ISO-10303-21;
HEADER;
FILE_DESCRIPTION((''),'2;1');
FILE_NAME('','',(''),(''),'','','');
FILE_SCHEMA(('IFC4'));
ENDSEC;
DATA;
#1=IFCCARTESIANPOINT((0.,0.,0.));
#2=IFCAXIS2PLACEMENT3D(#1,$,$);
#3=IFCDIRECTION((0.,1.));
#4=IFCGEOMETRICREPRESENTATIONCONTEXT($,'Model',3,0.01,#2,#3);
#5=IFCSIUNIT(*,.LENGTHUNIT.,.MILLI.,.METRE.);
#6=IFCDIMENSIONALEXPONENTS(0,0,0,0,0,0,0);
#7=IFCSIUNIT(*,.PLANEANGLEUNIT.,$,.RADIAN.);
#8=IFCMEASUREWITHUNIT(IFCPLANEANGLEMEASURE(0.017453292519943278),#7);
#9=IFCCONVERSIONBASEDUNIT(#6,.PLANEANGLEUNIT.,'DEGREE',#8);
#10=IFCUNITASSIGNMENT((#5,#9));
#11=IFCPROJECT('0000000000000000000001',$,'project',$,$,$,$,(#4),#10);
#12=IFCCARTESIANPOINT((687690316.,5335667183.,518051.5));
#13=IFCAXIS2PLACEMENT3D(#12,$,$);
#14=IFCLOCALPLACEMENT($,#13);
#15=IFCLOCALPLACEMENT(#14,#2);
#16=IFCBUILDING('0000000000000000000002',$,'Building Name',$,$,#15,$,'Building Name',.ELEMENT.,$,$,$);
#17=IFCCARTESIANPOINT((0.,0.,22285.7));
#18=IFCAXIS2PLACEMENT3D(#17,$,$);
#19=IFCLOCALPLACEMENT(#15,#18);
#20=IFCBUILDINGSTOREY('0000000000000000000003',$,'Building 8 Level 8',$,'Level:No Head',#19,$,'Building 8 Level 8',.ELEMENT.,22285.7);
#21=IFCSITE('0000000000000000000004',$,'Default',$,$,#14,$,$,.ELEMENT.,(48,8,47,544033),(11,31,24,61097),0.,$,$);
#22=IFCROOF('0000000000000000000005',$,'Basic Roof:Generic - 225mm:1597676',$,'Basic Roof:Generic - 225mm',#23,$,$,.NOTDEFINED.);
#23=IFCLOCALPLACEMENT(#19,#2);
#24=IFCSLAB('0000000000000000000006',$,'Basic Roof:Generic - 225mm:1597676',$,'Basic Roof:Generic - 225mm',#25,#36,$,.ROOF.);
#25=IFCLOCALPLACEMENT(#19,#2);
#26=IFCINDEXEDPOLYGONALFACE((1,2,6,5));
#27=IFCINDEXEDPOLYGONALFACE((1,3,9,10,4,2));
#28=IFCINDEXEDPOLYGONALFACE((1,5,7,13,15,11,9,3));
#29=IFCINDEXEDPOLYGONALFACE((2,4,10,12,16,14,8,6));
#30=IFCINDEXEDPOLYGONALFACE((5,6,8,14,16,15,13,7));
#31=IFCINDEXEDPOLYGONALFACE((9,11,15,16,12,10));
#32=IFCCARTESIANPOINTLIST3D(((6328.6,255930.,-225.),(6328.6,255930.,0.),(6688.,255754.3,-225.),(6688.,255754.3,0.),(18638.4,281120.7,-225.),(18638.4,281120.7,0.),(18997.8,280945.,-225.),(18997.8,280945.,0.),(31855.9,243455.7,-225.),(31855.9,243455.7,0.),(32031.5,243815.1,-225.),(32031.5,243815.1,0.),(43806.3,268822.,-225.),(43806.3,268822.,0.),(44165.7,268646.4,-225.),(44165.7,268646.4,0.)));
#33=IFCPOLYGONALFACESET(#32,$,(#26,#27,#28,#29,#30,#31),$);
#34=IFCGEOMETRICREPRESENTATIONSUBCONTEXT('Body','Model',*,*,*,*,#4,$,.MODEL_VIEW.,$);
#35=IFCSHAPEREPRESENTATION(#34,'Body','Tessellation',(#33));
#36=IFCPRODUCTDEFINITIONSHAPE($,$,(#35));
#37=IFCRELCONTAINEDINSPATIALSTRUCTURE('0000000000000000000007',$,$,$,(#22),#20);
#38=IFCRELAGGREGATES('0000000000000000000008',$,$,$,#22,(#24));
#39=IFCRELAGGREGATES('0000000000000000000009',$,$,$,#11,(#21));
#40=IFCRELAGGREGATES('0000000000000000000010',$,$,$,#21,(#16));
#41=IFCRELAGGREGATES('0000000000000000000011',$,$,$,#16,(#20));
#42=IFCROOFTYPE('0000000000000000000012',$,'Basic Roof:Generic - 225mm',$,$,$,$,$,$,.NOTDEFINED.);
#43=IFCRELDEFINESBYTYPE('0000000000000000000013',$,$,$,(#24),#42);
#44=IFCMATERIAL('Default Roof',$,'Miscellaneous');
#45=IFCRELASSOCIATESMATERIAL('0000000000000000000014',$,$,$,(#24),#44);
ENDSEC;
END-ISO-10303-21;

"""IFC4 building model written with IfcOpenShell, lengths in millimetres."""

from ifc_helpers import new_model, entity, si_unit, converted_unit, direction, frame, origin, place, context, subcontext, project, spatial, indexed_curve, outline, extrude, material, type_object, element, aggregate, save


model = new_model("IFC4")

# Units and contexts
model_context = context("Model", 3, precision=0.01, world=origin(), true_north=direction((0.0, 1.0)))
body_context = subcontext(model_context, "Body", "Model", "MODEL_VIEW")
ifc_project = project(units=[si_unit("LENGTHUNIT", "METRE", prefix="MILLI"), converted_unit("PLANEANGLEUNIT", "DEGREE", entity("IfcPlaneAngleMeasure", 0.017453292519943278), si_unit("PLANEANGLEUNIT", "RADIAN"), dimensions=[0, 0, 0, 0, 0, 0, 0])], contexts=[model_context])

# Site, building, storey
site_placement = place(None, frame((687690316.0, 5335667183.0, 518051.5)))
site = spatial("IfcSite", under=ifc_project, at=site_placement, Name="Default", CompositionType="ELEMENT", RefLatitude=(48, 8, 47, 544033), RefLongitude=(11, 31, 24, 61097), RefElevation=0.0)
building_placement = place(site_placement, origin())
building = spatial("IfcBuilding", under=site, at=building_placement, Name="Building Name", LongName="Building Name", CompositionType="ELEMENT")
storey_placement = place(building_placement, frame((0.0, 0.0, 22285.7)))
storey = spatial("IfcBuildingStorey", under=building, at=storey_placement, Name="Building 8 Level 8", ObjectType="Level:No Head", LongName="Building 8 Level 8", CompositionType="ELEMENT", Elevation=22285.7)

# Roof, slab
roof_placement = place(storey_placement, frame((6328.6, 243455.7, -225.0)))
roof = element("IfcRoof", 1, at=roof_placement, inside=storey, Name="Basic Roof:Generic - 225mm:1597676", ObjectType="Basic Roof:Generic - 225mm", PredefinedType="NOTDEFINED")
ifc_material = material(Name="Default Roof", Category="Miscellaneous")
roof_type = type_object("IfcRoofType", Name="Basic Roof:Generic - 225mm", PredefinedType="NOTDEFINED")
slab_placement = place(roof_placement, origin())
slab = element("IfcSlab", 2, at=slab_placement, type_object=roof_type, material=ifc_material, Name="Basic Roof:Generic - 225mm:1597676", ObjectType="Basic Roof:Generic - 225mm", PredefinedType="ROOF", context=body_context, shape_type="SweptSolid", body=[
    extrude(outline(indexed_curve([(6608.8, -18832.5), (6784.4, -18473.1), (18918.5, 6358.2), (18559.1, 6533.9), (-6249.4, 18656.9), (-6608.8, 18832.5), (-18918.5, -6358.2), (-18559.1, -6533.9), (6608.8, -18832.5)], self_intersect=False)), frame((18918.5, 18832.5, 0.0)), (0.0, 0.0, 1.0), 225.0),
])
aggregate(roof, [slab])

save(model, "model.ifc")
